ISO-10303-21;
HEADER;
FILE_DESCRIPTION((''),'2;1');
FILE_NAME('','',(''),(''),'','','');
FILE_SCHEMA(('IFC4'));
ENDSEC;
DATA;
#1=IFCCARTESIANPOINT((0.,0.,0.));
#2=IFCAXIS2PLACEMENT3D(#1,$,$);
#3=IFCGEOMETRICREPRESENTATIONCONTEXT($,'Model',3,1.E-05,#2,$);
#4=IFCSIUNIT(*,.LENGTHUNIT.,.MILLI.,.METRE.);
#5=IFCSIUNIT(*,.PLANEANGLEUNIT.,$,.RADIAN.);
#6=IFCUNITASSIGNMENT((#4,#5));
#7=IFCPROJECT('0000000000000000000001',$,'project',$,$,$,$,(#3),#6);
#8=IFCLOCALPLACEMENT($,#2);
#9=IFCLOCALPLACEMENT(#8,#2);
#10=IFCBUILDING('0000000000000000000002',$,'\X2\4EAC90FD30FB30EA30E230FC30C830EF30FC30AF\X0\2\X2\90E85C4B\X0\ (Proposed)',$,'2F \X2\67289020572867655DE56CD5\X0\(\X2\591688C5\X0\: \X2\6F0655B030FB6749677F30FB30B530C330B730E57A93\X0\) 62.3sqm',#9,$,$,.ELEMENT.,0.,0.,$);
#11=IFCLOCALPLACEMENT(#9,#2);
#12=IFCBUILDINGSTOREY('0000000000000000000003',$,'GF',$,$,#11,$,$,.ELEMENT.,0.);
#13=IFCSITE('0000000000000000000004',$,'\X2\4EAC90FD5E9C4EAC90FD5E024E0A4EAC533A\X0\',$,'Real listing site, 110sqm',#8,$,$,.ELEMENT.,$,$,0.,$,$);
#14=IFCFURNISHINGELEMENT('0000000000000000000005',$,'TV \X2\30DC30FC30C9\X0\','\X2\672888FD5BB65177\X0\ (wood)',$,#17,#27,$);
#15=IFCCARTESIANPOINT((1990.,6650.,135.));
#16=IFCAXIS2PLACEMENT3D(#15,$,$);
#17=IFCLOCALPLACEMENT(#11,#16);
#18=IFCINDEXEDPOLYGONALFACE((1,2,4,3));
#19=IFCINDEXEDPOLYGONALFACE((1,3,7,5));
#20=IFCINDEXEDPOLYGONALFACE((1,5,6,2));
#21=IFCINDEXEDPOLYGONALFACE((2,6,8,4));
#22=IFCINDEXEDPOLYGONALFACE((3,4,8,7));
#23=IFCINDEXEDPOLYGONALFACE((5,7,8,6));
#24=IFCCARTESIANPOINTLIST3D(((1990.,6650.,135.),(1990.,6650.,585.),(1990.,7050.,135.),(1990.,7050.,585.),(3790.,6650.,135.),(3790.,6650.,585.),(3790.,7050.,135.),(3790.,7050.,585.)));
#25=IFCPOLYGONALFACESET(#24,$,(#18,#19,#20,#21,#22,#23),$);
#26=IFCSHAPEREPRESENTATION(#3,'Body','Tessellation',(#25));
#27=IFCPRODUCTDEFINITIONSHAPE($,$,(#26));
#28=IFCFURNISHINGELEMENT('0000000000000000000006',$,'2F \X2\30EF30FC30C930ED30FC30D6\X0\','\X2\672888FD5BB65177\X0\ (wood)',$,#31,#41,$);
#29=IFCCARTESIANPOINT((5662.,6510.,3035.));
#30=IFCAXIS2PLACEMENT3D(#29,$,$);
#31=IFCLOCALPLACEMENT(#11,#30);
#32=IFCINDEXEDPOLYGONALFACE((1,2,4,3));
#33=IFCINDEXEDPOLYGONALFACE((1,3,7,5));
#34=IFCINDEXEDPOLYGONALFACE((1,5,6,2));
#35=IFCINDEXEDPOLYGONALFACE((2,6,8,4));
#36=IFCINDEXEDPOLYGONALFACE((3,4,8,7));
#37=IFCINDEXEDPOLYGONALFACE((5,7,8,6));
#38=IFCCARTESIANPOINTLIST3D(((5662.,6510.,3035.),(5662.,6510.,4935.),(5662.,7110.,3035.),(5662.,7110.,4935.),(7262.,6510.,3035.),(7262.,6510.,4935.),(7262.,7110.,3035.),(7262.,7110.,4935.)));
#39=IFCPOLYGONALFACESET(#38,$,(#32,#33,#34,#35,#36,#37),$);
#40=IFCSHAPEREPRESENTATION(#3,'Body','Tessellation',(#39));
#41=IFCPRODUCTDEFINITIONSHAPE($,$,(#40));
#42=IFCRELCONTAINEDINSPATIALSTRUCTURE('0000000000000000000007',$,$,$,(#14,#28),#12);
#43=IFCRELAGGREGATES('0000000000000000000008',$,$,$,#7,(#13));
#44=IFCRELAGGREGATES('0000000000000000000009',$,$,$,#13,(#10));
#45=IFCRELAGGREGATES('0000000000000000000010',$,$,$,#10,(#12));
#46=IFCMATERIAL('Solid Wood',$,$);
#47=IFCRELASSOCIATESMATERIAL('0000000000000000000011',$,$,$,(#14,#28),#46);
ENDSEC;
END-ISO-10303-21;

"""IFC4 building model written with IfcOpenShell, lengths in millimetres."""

from ifc_helpers import new_model, si_unit, frame, frame_2d, origin, place, context, project, spatial, rectangle, extrude, material, element, save


model = new_model("IFC4")

# Units and contexts
model_context = context("Model", 3, precision=1e-05, world=origin())
ifc_project = project(units=[si_unit("LENGTHUNIT", "METRE", prefix="MILLI"), si_unit("PLANEANGLEUNIT", "RADIAN")], contexts=[model_context])

# Site, building, storey
site_placement = place(None, origin())
site = spatial("IfcSite", under=ifc_project, at=site_placement, Name="京都府京都市上京区", ObjectType="Real listing site, 110sqm", CompositionType="ELEMENT", RefElevation=0.0)
building_placement = place(site_placement, origin())
building = spatial("IfcBuilding", under=site, at=building_placement, Name="京都・リモートワーク2部屋 (Proposed)", ObjectType="2F 木造在来工法(外装: 漆喰・杉板・サッシュ窓) 62.3sqm", CompositionType="ELEMENT", ElevationOfRefHeight=0.0, ElevationOfTerrain=0.0)
storey_placement = place(building_placement, origin())
storey = spatial("IfcBuildingStorey", under=building, at=storey_placement, Name="GF", CompositionType="ELEMENT", Elevation=0.0)

# Shared definitions
ifc_material_1 = material(Name="Solid Wood")

# Furnishing elements
furnishing_1_placement = place(storey_placement, frame((1990.0, 6650.0, 135.0)))
element("IfcFurnishingElement", 1, at=furnishing_1_placement, inside=storey, material=ifc_material_1, Name="TV ボード", Description="木製家具 (wood)", context=model_context, shape_type="SweptSolid", body=[
    extrude(rectangle(XDim=1800.0, YDim=400.0, at=frame_2d((900.0, 200.0))), frame((1990.0, 6650.0, 135.0)), (0.0, 0.0, 1.0), 450.0),
])
furnishing_2_placement = place(storey_placement, frame((5662.0, 6510.0, 3035.0)))
element("IfcFurnishingElement", 2, at=furnishing_2_placement, inside=storey, material=ifc_material_1, Name="2F ワードローブ", Description="木製家具 (wood)", context=model_context, shape_type="SweptSolid", body=[
    extrude(rectangle(XDim=1600.0, YDim=600.0, at=frame_2d((800.0, 300.0))), frame((5662.0, 6510.0, 3035.0)), (0.0, 0.0, 1.0), 1900.0),
])

save(model, "model.ifc")
